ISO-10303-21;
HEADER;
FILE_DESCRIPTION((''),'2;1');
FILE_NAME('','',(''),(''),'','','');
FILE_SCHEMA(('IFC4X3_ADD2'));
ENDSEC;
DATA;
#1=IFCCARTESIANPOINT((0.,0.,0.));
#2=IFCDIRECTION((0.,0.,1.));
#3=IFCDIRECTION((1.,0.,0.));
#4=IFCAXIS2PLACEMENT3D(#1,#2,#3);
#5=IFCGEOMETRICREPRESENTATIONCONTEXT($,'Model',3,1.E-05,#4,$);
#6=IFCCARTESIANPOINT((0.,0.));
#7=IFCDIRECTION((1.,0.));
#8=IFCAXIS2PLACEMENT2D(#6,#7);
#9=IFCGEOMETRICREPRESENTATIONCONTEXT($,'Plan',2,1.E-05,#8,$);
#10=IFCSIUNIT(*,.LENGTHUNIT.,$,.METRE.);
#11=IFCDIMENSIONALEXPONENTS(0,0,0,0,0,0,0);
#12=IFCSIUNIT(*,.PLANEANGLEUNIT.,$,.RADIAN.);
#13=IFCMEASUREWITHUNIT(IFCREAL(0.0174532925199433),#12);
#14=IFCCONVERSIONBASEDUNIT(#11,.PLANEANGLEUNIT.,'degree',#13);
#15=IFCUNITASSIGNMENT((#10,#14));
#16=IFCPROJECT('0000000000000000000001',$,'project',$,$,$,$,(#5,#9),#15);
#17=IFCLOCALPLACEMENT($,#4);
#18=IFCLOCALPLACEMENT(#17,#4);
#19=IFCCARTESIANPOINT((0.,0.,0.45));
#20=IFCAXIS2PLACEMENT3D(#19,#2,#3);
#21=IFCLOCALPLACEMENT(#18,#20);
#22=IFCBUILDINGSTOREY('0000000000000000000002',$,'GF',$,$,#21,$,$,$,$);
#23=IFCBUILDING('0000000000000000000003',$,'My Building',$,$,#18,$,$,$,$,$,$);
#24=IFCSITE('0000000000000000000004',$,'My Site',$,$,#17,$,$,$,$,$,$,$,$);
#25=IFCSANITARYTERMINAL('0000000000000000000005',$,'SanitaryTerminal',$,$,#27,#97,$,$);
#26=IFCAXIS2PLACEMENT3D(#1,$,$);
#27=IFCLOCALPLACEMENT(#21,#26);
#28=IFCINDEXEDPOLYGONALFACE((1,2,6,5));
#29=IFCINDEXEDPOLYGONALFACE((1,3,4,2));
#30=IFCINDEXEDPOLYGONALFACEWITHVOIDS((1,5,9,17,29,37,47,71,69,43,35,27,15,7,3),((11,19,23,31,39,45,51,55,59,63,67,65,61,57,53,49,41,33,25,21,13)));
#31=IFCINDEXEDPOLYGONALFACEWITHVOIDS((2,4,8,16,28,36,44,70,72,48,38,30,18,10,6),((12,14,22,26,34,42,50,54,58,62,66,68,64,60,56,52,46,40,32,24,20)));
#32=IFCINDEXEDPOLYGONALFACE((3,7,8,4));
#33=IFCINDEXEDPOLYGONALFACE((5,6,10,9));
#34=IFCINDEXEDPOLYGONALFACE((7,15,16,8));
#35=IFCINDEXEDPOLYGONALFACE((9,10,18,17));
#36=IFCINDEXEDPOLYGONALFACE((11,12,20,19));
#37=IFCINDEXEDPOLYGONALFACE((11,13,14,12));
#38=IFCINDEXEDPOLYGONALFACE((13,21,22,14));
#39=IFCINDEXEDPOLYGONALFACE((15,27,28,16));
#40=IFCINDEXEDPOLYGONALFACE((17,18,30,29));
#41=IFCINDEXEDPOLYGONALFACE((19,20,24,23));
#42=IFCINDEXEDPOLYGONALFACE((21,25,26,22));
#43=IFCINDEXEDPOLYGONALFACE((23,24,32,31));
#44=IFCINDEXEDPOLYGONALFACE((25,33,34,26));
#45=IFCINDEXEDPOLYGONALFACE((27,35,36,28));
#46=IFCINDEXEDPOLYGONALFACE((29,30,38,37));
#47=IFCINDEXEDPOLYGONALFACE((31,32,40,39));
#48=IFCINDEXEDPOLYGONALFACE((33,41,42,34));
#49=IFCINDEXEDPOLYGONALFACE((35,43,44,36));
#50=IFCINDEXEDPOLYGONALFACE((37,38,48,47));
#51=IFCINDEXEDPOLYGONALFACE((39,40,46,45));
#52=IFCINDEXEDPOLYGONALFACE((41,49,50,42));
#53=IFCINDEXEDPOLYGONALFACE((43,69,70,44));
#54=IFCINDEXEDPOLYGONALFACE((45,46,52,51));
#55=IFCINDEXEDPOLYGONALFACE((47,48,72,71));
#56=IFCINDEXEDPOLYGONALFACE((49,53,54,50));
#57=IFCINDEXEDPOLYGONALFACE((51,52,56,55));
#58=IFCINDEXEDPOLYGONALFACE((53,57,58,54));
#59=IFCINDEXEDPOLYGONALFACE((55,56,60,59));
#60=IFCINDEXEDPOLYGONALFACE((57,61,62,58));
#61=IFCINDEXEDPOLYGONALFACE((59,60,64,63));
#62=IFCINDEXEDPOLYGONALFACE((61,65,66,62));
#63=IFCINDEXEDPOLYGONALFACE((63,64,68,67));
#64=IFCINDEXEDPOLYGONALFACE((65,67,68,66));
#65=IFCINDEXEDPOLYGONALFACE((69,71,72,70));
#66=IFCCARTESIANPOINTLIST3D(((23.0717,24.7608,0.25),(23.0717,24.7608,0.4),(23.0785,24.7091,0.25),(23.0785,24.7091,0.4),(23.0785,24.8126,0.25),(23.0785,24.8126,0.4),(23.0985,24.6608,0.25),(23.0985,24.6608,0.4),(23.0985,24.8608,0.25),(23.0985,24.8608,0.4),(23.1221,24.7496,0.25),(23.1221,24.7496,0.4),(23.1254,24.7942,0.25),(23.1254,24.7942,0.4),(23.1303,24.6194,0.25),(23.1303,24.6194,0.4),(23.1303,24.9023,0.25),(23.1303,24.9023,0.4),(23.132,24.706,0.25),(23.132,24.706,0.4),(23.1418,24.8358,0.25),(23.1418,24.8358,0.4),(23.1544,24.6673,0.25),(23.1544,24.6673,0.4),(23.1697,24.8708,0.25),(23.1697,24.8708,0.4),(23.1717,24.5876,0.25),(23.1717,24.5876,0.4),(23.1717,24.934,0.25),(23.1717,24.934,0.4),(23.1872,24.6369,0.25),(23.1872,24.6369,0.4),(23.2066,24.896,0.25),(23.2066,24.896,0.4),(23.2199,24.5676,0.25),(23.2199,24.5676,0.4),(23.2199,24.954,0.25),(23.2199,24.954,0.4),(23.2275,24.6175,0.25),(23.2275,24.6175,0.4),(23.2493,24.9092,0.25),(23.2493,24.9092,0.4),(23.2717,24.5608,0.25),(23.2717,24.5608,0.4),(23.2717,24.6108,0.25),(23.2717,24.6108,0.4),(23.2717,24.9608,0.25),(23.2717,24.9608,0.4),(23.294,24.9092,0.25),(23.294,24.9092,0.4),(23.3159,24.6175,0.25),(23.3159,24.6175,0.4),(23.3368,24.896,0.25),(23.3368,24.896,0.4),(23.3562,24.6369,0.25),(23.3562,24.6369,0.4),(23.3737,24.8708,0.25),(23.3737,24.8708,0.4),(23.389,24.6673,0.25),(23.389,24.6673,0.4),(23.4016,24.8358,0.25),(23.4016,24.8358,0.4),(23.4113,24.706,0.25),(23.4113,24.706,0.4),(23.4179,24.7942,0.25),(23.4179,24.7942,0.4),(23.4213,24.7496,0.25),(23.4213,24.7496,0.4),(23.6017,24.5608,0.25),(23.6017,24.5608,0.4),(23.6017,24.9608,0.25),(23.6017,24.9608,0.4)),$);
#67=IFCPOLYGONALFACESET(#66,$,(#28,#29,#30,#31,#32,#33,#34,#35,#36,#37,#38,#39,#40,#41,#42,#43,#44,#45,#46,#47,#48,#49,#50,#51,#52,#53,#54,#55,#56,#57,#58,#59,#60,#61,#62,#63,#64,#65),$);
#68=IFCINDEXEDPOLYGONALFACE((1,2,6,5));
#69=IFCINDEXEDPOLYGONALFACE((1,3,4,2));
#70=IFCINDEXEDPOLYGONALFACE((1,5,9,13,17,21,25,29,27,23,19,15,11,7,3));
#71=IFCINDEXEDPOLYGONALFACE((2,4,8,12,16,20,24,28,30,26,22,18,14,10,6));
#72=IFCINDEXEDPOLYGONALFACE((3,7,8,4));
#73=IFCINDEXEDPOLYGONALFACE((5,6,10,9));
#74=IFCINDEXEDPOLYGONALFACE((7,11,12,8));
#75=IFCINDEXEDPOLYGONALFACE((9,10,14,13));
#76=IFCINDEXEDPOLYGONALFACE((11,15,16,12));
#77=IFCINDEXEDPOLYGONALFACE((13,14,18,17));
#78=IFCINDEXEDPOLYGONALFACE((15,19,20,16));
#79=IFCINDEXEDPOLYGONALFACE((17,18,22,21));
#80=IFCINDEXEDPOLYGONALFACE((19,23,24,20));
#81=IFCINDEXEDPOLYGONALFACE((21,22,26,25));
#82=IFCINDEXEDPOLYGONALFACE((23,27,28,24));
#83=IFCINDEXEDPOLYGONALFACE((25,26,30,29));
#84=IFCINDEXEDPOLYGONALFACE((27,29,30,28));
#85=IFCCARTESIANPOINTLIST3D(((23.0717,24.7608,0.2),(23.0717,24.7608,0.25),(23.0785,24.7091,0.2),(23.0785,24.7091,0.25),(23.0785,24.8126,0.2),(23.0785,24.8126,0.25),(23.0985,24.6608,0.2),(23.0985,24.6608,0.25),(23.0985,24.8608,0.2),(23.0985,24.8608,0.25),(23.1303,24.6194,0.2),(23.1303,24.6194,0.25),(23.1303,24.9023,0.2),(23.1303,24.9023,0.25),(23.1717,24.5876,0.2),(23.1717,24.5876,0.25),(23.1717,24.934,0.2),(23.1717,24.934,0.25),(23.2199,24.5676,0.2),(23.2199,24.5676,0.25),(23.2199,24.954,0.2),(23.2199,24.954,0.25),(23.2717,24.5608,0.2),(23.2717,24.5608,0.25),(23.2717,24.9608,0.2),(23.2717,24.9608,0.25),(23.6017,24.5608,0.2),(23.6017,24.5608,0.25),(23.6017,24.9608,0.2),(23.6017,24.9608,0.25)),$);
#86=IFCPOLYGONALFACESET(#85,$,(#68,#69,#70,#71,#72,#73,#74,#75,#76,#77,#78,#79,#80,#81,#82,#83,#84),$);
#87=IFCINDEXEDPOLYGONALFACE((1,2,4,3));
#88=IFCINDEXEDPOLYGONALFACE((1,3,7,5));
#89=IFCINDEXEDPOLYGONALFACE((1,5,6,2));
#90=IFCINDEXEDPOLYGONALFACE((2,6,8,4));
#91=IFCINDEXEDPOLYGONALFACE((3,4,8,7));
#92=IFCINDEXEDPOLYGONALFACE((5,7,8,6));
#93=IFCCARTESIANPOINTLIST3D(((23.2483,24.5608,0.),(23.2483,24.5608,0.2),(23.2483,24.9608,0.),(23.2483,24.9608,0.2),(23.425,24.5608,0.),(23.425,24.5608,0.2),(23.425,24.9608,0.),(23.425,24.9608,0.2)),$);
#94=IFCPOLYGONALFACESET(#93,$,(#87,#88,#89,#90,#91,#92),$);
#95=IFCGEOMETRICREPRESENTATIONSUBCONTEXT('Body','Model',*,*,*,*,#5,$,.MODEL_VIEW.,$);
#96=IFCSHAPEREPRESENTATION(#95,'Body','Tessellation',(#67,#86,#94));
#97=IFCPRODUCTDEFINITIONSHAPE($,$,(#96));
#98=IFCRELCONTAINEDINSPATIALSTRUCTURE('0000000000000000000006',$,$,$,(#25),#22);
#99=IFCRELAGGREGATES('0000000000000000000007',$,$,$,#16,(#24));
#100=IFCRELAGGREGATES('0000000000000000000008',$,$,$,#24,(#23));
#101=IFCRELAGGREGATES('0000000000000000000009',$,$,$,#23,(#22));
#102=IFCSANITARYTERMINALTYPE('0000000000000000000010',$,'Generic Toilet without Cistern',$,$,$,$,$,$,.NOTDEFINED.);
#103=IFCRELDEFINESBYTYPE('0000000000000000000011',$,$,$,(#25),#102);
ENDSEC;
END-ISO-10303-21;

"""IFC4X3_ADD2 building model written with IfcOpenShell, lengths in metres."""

from ifc_helpers import new_model, entity, si_unit, converted_unit, frame, frame_2d, origin_with_axes, origin_2d_with_axis, place, context, subcontext, project, spatial, line, arc, indexed_curve, circle_curve, outline, extrude, shape, source, transform, mapped, type_object, type_shapes, element, save


model = new_model("IFC4X3_ADD2")

# Units and contexts
model_context = context("Model", 3, precision=1e-05, world=origin_with_axes())
plan_context = context("Plan", 2, precision=1e-05, world=origin_2d_with_axis())
body_context_1 = subcontext(model_context, "Body", "Model", "MODEL_VIEW")
body_context_2 = subcontext(plan_context, "Body", "Plan", "PLAN_VIEW")
ifc_project = project(units=[si_unit("LENGTHUNIT", "METRE"), converted_unit("PLANEANGLEUNIT", "degree", entity("IfcReal", 0.0174532925199433), si_unit("PLANEANGLEUNIT", "RADIAN"), dimensions=[0, 0, 0, 0, 0, 0, 0])], contexts=[model_context, plan_context])

# Site, building, storey
site_placement = place(None, origin_with_axes())
site = spatial("IfcSite", under=ifc_project, at=site_placement, Name="My Site")
building_placement = place(site_placement, origin_with_axes())
building = spatial("IfcBuilding", under=site, at=building_placement, Name="My Building")
storey_placement = place(building_placement, frame((0.0, 0.0, 0.45), z_axis=(0.0, 0.0, 1.0), x_axis=(1.0, 0.0, 0.0)))
storey = spatial("IfcBuildingStorey", under=building, at=storey_placement, Name="GF")

# Sanitary terminal
sanitary_terminal_type_1 = type_object("IfcSanitaryTerminalType", Name="Generic Toilet without Cistern", PredefinedType="NOTDEFINED")
shared_shape_1 = source(origin_with_axes(), body_context_1, "Body", "SweptSolid", [
    extrude(outline(indexed_curve([(-0.2, 0.0), (0.2, 0.0), (0.2, -0.33), (0.1414, -0.4714), (0.0, -0.53), (-0.1414, -0.4714), (-0.2, -0.33)], segments=[line(1, 2), line(2, 3), arc(3, 4, 5), arc(5, 6, 7), line(7, 1)]), holes=[circle_curve(frame_2d((0.0, -0.33)), 0.15)]), frame((0.0, 0.0, 0.25), z_axis=(0.0, 0.0, 1.0), x_axis=(1.0, 0.0, 0.0)), (0.0, 0.0, 1.0), 0.15),
    extrude(outline(indexed_curve([(-0.2, 0.0), (0.2, 0.0), (0.2, -0.33), (0.1414, -0.4714), (0.0, -0.53), (-0.1414, -0.4714), (-0.2, -0.33)], segments=[line(1, 2), line(2, 3), arc(3, 4, 5), arc(5, 6, 7), line(7, 1)])), frame((0.0, 0.0, 0.2), z_axis=(0.0, 0.0, 1.0), x_axis=(1.0, 0.0, 0.0)), (0.0, 0.0, 1.0), 0.05),
    extrude(outline(indexed_curve([(-0.2, -0.1767), (0.2, -0.1767), (0.2, -0.3533), (-0.2, -0.3533)], segments=[line(1, 2, 3, 4, 1)])), origin_with_axes(), (0.0, 0.0, 1.0), 0.2),
])
shared_shape_2 = source(origin_with_axes(), body_context_2, "Body", "Annotation2D", [
    entity("IfcGeometricCurveSet", [entity("IfcIndexedPolyCurve", entity("IfcCartesianPointList2D", [[-0.1068, -0.124], [-0.0957, -0.1129], [-0.0804, -0.1088], [0.0804, -0.1088], [0.0957, -0.1129], [0.1068, -0.124], [0.1109, -0.1393], [0.1109, -0.3476], [0.1025, -0.3926], [0.0784, -0.4308], [0.0424, -0.4563], [0.0, -0.4652], [-0.0424, -0.4563], [-0.0784, -0.4308], [-0.1025, -0.3926], [-0.1109, -0.3476], [-0.1109, -0.1393]]), [entity("IfcLineIndex", [1, 2, 3, 4, 5, 6, 7, 8, 9, 10, 11, 12, 13, 14, 15, 16, 17, 1])]), entity("IfcIndexedPolyCurve", entity("IfcCartesianPointList2D", [[-0.1962, -0.2314], [-0.1848, -0.301], [-0.1764, -0.3339], [-0.1663, -0.3651], [-0.1546, -0.3944], [-0.1414, -0.4213], [-0.1269, -0.4458], [-0.1111, -0.4675], [-0.0943, -0.4862], [-0.0765, -0.5018], [-0.0581, -0.514], [-0.039, -0.5229], [-0.0196, -0.5282], [0.0, -0.53], [0.0196, -0.5282], [0.039, -0.5229], [0.0581, -0.514], [0.0765, -0.5018], [0.0943, -0.4862], [0.1111, -0.4675], [0.1269, -0.4458], [0.1414, -0.4213], [0.1546, -0.3944], [0.1663, -0.3651], [0.1764, -0.3339], [0.1848, -0.301], [0.1962, -0.2314], [0.2, -0.159], [0.1872, 0.0], [-0.1872, 0.0], [-0.2, -0.159]]), [entity("IfcLineIndex", [1, 2, 3, 4, 5, 6, 7, 8, 9, 10, 11, 12, 13, 14, 15, 16, 17, 18, 19, 20, 21, 22, 23, 24, 25, 26, 27, 28, 29, 30, 31, 1])])]),
])
type_shapes(sanitary_terminal_type_1, [shared_shape_1, shared_shape_2])
sanitary_terminal_1_placement = place(storey_placement, frame((23.6017, 24.7608, 0.0), z_axis=(0.0, 0.0, 1.0), x_axis=(0.0, -1.0, 0.0)))
element("IfcSanitaryTerminal", 1, at=sanitary_terminal_1_placement, inside=storey, type_object=sanitary_terminal_type_1, Name="SanitaryTerminal", shapes=[
    shape(body_context_1, "Body", "MappedRepresentation", [mapped(shared_shape_1, transform((0.0, 0.0, 0.0), x_axis=(1.0, 0.0, 0.0), y_axis=(0.0, 1.0, 0.0), z_axis=(0.0, 0.0, 1.0), scale=1.0))]),
    shape(body_context_2, "Body", "MappedRepresentation", [mapped(shared_shape_2, transform((0.0, 0.0, 0.0), x_axis=(1.0, 0.0, 0.0), y_axis=(0.0, 1.0, 0.0), z_axis=(0.0, 0.0, 1.0), scale=1.0))]),
])

save(model, "model.ifc")
